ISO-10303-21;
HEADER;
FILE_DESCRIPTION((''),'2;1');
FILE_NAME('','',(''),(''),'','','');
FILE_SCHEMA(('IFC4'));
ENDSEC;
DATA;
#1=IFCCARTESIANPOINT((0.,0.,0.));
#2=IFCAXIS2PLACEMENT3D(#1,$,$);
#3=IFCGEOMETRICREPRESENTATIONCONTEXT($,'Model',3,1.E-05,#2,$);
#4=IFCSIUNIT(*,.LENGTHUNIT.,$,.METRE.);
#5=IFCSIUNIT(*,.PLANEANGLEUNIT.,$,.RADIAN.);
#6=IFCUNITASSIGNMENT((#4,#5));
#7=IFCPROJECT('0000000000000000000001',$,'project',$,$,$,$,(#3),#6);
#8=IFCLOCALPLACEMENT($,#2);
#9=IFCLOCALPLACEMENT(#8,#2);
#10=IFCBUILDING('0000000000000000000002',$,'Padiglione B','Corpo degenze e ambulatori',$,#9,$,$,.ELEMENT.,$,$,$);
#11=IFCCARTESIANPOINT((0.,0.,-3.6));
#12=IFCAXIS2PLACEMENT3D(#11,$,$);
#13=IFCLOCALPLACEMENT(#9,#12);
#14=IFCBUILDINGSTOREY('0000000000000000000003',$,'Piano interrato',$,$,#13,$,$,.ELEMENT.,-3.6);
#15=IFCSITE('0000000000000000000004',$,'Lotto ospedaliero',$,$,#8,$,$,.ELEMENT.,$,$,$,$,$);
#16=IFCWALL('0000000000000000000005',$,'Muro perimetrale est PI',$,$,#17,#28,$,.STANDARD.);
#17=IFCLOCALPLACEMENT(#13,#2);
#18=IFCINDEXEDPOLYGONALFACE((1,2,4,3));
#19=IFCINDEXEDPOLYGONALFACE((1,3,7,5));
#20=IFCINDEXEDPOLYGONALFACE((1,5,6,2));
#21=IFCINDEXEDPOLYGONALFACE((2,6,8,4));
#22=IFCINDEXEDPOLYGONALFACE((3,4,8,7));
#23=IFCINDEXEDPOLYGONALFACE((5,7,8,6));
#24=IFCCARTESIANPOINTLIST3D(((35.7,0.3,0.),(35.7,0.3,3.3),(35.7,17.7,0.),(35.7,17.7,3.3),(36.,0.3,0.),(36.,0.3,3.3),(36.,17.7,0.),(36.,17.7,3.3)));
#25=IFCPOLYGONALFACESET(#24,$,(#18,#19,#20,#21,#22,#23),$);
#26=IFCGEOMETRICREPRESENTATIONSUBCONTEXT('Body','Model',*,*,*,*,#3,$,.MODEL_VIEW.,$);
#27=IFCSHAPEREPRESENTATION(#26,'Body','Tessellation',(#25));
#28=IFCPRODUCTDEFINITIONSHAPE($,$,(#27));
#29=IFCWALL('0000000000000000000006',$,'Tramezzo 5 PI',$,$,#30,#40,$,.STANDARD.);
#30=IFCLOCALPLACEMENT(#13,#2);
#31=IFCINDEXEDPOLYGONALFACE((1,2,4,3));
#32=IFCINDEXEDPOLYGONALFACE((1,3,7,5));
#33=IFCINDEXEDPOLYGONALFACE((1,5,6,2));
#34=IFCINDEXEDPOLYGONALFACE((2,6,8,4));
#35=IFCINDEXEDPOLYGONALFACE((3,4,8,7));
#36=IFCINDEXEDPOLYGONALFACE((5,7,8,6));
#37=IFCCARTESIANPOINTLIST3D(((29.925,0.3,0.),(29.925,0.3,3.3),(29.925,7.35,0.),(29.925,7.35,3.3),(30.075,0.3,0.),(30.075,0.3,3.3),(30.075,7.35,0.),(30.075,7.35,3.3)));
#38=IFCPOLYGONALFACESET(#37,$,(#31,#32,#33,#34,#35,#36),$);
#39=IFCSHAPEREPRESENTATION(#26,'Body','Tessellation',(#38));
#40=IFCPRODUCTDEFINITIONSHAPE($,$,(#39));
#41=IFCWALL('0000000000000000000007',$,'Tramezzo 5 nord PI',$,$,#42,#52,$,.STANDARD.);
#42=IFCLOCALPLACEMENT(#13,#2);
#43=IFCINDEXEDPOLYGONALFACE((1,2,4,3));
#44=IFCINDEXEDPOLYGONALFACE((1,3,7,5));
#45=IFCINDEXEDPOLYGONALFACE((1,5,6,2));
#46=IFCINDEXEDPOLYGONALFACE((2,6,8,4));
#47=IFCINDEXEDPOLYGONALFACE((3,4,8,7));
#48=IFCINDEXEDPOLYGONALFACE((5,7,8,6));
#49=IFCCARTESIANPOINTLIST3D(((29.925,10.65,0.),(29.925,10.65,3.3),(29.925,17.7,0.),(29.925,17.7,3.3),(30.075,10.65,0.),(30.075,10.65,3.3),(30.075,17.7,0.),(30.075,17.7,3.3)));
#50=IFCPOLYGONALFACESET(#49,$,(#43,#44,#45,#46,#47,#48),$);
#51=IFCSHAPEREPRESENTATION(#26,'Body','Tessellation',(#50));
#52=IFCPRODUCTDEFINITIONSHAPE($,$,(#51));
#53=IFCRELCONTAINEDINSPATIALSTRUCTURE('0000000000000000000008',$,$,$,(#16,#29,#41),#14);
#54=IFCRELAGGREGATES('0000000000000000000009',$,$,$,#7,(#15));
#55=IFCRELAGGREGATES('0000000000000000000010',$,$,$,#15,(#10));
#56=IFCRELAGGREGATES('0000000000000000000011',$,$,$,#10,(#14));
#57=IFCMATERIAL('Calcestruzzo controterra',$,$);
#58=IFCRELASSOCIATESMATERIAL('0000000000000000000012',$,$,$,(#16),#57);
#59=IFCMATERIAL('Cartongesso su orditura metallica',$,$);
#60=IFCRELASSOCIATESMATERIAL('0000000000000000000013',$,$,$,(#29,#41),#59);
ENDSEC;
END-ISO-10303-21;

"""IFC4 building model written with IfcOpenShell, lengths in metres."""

from ifc_helpers import new_model, si_unit, frame, frame_2d, origin, place, context, subcontext, project, spatial, rectangle, extrude, material, element, save


model = new_model("IFC4")

# Units and contexts
model_context = context("Model", 3, precision=1e-05, world=origin())
body_context = subcontext(model_context, "Body", "Model", "MODEL_VIEW")
ifc_project = project(units=[si_unit("LENGTHUNIT", "METRE"), si_unit("PLANEANGLEUNIT", "RADIAN")], contexts=[model_context])

# Site, building, storey
site_placement = place(None, origin())
site = spatial("IfcSite", under=ifc_project, at=site_placement, Name="Lotto ospedaliero", CompositionType="ELEMENT")
building_placement = place(site_placement, origin())
building = spatial("IfcBuilding", under=site, at=building_placement, Name="Padiglione B", Description="Corpo degenze e ambulatori", CompositionType="ELEMENT")
storey_placement = place(building_placement, frame((0.0, 0.0, -3.6)))
storey = spatial("IfcBuildingStorey", under=building, at=storey_placement, Name="Piano interrato", CompositionType="ELEMENT", Elevation=-3.6)

# Walls
ifc_material_1 = material(Name="Calcestruzzo controterra")
wall_placement = place(storey_placement, frame((35.7, 0.3, 0.0)))
element("IfcWall", 1, at=wall_placement, inside=storey, material=ifc_material_1, Name="Muro perimetrale est PI", PredefinedType="STANDARD", context=body_context, shape_type="SweptSolid", body=[
    extrude(rectangle(XDim=0.3, YDim=17.4, at=frame_2d((0.15, 8.7))), origin(), (0.0, 0.0, 1.0), 3.3),
])
ifc_material_2 = material(Name="Cartongesso su orditura metallica")
for number, where, name in (
    (2, (29.925, 0.3, 0.0), "Tramezzo 5 PI"),
    (3, (29.925, 10.65, 0.0), "Tramezzo 5 nord PI"),
):
    element("IfcWall", number, at=place(storey_placement, frame(where)), inside=storey, material=ifc_material_2, Name=name, PredefinedType="STANDARD", context=body_context, shape_type="SweptSolid", body=[
        extrude(rectangle(XDim=0.15, YDim=7.05, at=frame_2d((0.075, 3.525))), origin(), (0.0, 0.0, 1.0), 3.3),
    ])

save(model, "model.ifc")
